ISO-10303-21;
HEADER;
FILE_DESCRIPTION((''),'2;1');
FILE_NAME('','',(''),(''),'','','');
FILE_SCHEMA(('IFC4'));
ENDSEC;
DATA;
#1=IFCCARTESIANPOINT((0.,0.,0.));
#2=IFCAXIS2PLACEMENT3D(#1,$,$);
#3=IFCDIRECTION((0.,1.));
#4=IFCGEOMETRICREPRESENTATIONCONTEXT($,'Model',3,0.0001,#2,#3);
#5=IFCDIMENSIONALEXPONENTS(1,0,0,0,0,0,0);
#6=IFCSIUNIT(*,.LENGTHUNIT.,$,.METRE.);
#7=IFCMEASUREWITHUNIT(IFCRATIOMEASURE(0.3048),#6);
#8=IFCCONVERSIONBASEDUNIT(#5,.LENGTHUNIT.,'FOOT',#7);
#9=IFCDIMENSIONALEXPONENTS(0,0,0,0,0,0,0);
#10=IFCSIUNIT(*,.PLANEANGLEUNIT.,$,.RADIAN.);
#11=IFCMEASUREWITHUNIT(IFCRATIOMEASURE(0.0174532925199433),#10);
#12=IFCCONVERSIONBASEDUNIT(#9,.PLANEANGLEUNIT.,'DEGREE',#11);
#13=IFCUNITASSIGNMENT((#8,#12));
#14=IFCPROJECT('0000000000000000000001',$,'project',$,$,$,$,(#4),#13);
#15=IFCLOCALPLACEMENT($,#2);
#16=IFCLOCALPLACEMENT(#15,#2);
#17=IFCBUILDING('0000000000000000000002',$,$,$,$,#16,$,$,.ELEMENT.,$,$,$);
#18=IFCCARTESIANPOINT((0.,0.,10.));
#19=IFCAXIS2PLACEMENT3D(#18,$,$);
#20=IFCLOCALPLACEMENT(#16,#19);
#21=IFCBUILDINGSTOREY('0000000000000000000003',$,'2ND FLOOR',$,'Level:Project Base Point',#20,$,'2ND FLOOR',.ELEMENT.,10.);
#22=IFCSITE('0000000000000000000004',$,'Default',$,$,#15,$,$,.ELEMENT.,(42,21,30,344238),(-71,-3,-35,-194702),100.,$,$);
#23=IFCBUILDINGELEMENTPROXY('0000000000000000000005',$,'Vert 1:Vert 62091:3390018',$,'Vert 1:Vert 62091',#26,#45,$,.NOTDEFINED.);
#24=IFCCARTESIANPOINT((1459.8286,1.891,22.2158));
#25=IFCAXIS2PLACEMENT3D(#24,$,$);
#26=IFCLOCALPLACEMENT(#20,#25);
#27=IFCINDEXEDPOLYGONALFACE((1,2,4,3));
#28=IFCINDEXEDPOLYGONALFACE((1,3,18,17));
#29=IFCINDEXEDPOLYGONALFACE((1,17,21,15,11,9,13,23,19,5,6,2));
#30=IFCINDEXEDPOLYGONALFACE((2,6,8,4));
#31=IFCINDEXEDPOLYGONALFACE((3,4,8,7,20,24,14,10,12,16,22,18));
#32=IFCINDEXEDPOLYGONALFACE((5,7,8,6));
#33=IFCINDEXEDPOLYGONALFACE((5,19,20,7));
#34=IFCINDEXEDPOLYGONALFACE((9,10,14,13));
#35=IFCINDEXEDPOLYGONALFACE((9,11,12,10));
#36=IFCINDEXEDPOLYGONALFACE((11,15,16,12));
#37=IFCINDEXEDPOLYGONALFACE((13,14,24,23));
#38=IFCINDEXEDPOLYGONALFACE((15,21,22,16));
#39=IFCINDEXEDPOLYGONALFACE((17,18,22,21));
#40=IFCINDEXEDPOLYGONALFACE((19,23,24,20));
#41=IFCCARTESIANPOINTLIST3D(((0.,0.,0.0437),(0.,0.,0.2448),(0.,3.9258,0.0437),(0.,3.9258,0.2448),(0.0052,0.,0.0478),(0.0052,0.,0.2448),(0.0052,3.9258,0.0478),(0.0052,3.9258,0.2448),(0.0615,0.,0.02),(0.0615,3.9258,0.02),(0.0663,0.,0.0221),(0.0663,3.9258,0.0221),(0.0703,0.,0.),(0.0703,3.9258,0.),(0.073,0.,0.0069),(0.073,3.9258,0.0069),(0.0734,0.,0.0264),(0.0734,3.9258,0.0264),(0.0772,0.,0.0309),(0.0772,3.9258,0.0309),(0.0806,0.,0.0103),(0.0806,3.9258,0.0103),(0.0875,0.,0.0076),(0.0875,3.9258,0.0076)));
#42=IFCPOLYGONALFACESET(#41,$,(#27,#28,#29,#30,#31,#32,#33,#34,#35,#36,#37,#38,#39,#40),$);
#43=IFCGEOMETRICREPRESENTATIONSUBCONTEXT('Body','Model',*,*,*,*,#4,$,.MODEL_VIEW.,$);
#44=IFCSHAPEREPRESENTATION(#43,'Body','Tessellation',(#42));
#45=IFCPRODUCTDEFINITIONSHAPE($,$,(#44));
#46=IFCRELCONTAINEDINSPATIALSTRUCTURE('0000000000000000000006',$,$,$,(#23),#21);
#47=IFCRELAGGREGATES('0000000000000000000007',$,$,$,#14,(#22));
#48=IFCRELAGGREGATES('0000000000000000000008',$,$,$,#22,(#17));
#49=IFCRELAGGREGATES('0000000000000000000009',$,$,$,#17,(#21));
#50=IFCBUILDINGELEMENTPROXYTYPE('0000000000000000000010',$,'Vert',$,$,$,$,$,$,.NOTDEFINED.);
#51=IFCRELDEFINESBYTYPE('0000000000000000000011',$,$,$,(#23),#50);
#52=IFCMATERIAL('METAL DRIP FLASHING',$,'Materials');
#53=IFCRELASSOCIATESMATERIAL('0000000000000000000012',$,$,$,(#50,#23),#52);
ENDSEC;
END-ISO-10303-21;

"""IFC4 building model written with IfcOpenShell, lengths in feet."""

from ifc_helpers import new_model, entity, si_unit, converted_unit, direction, frame, origin, place, context, subcontext, project, spatial, polyline, outline, extrude, source, transform, mapped, material, type_object, type_shapes, element, save


model = new_model("IFC4")

# Units and contexts
model_context = context("Model", 3, precision=0.0001, world=origin(), true_north=direction((0.0, 1.0)))
body_context = subcontext(model_context, "Body", "Model", "MODEL_VIEW")
ifc_project = project(units=[converted_unit("LENGTHUNIT", "FOOT", entity("IfcRatioMeasure", 0.3048), si_unit("LENGTHUNIT", "METRE"), dimensions=[1, 0, 0, 0, 0, 0, 0]), converted_unit("PLANEANGLEUNIT", "DEGREE", entity("IfcRatioMeasure", 0.0174532925199433), si_unit("PLANEANGLEUNIT", "RADIAN"), dimensions=[0, 0, 0, 0, 0, 0, 0])], contexts=[model_context])

# Site, building, storey
site_placement = place(None, origin())
site = spatial("IfcSite", under=ifc_project, at=site_placement, Name="Default", CompositionType="ELEMENT", RefLatitude=(42, 21, 30, 344238), RefLongitude=(-71, -3, -35, -194702), RefElevation=100.0)
building_placement = place(site_placement, origin())
building = spatial("IfcBuilding", under=site, at=building_placement, CompositionType="ELEMENT")
storey_placement = place(building_placement, frame((0.0, 0.0, 10.0)))
storey = spatial("IfcBuildingStorey", under=building, at=storey_placement, Name="2ND FLOOR", ObjectType="Level:Project Base Point", LongName="2ND FLOOR", CompositionType="ELEMENT", Elevation=10.0)

# Building element proxy
ifc_material_1 = material(Name="METAL DRIP FLASHING", Category="Materials")
building_element_proxy_type_1 = type_object("IfcBuildingElementProxyType", Name="Vert", PredefinedType="NOTDEFINED", material=ifc_material_1)
shared_shape_1 = source(origin(), body_context, "Body", "SweptSolid", [
    extrude(outline(polyline([(-0.0411, 0.0209), (0.0328, 0.0209), (0.0482, 0.0413), (0.0332, 0.0526), (0.02, 0.0351), (0.0242, 0.0319), (0.0342, 0.0452), (0.0408, 0.0402), (0.0302, 0.0261), (-0.0452, 0.0261), (-0.0913, -0.1696), (-0.0862, -0.1708), (-0.0411, 0.0209)])), frame((0.05, 0.0, 0.0588), z_axis=(0.0, 1.0, 0.0), x_axis=(0.97343, 0.0, -0.228986)), (0.0, 0.0, 1.0), 3.9258),
])
type_shapes(building_element_proxy_type_1, [shared_shape_1])
proxy_1_placement = place(storey_placement, frame((1459.8286, 1.891, 22.2158)))
element("IfcBuildingElementProxy", 1, at=proxy_1_placement, inside=storey, type_object=building_element_proxy_type_1, material=ifc_material_1, Name="Vert 1:Vert 62091:3390018", ObjectType="Vert 1:Vert 62091", PredefinedType="NOTDEFINED", context=body_context, shape_type="MappedRepresentation", body=[
    mapped(shared_shape_1, transform((0.0, 0.0, 0.0), scale=1.0)),
])

save(model, "model.ifc")
